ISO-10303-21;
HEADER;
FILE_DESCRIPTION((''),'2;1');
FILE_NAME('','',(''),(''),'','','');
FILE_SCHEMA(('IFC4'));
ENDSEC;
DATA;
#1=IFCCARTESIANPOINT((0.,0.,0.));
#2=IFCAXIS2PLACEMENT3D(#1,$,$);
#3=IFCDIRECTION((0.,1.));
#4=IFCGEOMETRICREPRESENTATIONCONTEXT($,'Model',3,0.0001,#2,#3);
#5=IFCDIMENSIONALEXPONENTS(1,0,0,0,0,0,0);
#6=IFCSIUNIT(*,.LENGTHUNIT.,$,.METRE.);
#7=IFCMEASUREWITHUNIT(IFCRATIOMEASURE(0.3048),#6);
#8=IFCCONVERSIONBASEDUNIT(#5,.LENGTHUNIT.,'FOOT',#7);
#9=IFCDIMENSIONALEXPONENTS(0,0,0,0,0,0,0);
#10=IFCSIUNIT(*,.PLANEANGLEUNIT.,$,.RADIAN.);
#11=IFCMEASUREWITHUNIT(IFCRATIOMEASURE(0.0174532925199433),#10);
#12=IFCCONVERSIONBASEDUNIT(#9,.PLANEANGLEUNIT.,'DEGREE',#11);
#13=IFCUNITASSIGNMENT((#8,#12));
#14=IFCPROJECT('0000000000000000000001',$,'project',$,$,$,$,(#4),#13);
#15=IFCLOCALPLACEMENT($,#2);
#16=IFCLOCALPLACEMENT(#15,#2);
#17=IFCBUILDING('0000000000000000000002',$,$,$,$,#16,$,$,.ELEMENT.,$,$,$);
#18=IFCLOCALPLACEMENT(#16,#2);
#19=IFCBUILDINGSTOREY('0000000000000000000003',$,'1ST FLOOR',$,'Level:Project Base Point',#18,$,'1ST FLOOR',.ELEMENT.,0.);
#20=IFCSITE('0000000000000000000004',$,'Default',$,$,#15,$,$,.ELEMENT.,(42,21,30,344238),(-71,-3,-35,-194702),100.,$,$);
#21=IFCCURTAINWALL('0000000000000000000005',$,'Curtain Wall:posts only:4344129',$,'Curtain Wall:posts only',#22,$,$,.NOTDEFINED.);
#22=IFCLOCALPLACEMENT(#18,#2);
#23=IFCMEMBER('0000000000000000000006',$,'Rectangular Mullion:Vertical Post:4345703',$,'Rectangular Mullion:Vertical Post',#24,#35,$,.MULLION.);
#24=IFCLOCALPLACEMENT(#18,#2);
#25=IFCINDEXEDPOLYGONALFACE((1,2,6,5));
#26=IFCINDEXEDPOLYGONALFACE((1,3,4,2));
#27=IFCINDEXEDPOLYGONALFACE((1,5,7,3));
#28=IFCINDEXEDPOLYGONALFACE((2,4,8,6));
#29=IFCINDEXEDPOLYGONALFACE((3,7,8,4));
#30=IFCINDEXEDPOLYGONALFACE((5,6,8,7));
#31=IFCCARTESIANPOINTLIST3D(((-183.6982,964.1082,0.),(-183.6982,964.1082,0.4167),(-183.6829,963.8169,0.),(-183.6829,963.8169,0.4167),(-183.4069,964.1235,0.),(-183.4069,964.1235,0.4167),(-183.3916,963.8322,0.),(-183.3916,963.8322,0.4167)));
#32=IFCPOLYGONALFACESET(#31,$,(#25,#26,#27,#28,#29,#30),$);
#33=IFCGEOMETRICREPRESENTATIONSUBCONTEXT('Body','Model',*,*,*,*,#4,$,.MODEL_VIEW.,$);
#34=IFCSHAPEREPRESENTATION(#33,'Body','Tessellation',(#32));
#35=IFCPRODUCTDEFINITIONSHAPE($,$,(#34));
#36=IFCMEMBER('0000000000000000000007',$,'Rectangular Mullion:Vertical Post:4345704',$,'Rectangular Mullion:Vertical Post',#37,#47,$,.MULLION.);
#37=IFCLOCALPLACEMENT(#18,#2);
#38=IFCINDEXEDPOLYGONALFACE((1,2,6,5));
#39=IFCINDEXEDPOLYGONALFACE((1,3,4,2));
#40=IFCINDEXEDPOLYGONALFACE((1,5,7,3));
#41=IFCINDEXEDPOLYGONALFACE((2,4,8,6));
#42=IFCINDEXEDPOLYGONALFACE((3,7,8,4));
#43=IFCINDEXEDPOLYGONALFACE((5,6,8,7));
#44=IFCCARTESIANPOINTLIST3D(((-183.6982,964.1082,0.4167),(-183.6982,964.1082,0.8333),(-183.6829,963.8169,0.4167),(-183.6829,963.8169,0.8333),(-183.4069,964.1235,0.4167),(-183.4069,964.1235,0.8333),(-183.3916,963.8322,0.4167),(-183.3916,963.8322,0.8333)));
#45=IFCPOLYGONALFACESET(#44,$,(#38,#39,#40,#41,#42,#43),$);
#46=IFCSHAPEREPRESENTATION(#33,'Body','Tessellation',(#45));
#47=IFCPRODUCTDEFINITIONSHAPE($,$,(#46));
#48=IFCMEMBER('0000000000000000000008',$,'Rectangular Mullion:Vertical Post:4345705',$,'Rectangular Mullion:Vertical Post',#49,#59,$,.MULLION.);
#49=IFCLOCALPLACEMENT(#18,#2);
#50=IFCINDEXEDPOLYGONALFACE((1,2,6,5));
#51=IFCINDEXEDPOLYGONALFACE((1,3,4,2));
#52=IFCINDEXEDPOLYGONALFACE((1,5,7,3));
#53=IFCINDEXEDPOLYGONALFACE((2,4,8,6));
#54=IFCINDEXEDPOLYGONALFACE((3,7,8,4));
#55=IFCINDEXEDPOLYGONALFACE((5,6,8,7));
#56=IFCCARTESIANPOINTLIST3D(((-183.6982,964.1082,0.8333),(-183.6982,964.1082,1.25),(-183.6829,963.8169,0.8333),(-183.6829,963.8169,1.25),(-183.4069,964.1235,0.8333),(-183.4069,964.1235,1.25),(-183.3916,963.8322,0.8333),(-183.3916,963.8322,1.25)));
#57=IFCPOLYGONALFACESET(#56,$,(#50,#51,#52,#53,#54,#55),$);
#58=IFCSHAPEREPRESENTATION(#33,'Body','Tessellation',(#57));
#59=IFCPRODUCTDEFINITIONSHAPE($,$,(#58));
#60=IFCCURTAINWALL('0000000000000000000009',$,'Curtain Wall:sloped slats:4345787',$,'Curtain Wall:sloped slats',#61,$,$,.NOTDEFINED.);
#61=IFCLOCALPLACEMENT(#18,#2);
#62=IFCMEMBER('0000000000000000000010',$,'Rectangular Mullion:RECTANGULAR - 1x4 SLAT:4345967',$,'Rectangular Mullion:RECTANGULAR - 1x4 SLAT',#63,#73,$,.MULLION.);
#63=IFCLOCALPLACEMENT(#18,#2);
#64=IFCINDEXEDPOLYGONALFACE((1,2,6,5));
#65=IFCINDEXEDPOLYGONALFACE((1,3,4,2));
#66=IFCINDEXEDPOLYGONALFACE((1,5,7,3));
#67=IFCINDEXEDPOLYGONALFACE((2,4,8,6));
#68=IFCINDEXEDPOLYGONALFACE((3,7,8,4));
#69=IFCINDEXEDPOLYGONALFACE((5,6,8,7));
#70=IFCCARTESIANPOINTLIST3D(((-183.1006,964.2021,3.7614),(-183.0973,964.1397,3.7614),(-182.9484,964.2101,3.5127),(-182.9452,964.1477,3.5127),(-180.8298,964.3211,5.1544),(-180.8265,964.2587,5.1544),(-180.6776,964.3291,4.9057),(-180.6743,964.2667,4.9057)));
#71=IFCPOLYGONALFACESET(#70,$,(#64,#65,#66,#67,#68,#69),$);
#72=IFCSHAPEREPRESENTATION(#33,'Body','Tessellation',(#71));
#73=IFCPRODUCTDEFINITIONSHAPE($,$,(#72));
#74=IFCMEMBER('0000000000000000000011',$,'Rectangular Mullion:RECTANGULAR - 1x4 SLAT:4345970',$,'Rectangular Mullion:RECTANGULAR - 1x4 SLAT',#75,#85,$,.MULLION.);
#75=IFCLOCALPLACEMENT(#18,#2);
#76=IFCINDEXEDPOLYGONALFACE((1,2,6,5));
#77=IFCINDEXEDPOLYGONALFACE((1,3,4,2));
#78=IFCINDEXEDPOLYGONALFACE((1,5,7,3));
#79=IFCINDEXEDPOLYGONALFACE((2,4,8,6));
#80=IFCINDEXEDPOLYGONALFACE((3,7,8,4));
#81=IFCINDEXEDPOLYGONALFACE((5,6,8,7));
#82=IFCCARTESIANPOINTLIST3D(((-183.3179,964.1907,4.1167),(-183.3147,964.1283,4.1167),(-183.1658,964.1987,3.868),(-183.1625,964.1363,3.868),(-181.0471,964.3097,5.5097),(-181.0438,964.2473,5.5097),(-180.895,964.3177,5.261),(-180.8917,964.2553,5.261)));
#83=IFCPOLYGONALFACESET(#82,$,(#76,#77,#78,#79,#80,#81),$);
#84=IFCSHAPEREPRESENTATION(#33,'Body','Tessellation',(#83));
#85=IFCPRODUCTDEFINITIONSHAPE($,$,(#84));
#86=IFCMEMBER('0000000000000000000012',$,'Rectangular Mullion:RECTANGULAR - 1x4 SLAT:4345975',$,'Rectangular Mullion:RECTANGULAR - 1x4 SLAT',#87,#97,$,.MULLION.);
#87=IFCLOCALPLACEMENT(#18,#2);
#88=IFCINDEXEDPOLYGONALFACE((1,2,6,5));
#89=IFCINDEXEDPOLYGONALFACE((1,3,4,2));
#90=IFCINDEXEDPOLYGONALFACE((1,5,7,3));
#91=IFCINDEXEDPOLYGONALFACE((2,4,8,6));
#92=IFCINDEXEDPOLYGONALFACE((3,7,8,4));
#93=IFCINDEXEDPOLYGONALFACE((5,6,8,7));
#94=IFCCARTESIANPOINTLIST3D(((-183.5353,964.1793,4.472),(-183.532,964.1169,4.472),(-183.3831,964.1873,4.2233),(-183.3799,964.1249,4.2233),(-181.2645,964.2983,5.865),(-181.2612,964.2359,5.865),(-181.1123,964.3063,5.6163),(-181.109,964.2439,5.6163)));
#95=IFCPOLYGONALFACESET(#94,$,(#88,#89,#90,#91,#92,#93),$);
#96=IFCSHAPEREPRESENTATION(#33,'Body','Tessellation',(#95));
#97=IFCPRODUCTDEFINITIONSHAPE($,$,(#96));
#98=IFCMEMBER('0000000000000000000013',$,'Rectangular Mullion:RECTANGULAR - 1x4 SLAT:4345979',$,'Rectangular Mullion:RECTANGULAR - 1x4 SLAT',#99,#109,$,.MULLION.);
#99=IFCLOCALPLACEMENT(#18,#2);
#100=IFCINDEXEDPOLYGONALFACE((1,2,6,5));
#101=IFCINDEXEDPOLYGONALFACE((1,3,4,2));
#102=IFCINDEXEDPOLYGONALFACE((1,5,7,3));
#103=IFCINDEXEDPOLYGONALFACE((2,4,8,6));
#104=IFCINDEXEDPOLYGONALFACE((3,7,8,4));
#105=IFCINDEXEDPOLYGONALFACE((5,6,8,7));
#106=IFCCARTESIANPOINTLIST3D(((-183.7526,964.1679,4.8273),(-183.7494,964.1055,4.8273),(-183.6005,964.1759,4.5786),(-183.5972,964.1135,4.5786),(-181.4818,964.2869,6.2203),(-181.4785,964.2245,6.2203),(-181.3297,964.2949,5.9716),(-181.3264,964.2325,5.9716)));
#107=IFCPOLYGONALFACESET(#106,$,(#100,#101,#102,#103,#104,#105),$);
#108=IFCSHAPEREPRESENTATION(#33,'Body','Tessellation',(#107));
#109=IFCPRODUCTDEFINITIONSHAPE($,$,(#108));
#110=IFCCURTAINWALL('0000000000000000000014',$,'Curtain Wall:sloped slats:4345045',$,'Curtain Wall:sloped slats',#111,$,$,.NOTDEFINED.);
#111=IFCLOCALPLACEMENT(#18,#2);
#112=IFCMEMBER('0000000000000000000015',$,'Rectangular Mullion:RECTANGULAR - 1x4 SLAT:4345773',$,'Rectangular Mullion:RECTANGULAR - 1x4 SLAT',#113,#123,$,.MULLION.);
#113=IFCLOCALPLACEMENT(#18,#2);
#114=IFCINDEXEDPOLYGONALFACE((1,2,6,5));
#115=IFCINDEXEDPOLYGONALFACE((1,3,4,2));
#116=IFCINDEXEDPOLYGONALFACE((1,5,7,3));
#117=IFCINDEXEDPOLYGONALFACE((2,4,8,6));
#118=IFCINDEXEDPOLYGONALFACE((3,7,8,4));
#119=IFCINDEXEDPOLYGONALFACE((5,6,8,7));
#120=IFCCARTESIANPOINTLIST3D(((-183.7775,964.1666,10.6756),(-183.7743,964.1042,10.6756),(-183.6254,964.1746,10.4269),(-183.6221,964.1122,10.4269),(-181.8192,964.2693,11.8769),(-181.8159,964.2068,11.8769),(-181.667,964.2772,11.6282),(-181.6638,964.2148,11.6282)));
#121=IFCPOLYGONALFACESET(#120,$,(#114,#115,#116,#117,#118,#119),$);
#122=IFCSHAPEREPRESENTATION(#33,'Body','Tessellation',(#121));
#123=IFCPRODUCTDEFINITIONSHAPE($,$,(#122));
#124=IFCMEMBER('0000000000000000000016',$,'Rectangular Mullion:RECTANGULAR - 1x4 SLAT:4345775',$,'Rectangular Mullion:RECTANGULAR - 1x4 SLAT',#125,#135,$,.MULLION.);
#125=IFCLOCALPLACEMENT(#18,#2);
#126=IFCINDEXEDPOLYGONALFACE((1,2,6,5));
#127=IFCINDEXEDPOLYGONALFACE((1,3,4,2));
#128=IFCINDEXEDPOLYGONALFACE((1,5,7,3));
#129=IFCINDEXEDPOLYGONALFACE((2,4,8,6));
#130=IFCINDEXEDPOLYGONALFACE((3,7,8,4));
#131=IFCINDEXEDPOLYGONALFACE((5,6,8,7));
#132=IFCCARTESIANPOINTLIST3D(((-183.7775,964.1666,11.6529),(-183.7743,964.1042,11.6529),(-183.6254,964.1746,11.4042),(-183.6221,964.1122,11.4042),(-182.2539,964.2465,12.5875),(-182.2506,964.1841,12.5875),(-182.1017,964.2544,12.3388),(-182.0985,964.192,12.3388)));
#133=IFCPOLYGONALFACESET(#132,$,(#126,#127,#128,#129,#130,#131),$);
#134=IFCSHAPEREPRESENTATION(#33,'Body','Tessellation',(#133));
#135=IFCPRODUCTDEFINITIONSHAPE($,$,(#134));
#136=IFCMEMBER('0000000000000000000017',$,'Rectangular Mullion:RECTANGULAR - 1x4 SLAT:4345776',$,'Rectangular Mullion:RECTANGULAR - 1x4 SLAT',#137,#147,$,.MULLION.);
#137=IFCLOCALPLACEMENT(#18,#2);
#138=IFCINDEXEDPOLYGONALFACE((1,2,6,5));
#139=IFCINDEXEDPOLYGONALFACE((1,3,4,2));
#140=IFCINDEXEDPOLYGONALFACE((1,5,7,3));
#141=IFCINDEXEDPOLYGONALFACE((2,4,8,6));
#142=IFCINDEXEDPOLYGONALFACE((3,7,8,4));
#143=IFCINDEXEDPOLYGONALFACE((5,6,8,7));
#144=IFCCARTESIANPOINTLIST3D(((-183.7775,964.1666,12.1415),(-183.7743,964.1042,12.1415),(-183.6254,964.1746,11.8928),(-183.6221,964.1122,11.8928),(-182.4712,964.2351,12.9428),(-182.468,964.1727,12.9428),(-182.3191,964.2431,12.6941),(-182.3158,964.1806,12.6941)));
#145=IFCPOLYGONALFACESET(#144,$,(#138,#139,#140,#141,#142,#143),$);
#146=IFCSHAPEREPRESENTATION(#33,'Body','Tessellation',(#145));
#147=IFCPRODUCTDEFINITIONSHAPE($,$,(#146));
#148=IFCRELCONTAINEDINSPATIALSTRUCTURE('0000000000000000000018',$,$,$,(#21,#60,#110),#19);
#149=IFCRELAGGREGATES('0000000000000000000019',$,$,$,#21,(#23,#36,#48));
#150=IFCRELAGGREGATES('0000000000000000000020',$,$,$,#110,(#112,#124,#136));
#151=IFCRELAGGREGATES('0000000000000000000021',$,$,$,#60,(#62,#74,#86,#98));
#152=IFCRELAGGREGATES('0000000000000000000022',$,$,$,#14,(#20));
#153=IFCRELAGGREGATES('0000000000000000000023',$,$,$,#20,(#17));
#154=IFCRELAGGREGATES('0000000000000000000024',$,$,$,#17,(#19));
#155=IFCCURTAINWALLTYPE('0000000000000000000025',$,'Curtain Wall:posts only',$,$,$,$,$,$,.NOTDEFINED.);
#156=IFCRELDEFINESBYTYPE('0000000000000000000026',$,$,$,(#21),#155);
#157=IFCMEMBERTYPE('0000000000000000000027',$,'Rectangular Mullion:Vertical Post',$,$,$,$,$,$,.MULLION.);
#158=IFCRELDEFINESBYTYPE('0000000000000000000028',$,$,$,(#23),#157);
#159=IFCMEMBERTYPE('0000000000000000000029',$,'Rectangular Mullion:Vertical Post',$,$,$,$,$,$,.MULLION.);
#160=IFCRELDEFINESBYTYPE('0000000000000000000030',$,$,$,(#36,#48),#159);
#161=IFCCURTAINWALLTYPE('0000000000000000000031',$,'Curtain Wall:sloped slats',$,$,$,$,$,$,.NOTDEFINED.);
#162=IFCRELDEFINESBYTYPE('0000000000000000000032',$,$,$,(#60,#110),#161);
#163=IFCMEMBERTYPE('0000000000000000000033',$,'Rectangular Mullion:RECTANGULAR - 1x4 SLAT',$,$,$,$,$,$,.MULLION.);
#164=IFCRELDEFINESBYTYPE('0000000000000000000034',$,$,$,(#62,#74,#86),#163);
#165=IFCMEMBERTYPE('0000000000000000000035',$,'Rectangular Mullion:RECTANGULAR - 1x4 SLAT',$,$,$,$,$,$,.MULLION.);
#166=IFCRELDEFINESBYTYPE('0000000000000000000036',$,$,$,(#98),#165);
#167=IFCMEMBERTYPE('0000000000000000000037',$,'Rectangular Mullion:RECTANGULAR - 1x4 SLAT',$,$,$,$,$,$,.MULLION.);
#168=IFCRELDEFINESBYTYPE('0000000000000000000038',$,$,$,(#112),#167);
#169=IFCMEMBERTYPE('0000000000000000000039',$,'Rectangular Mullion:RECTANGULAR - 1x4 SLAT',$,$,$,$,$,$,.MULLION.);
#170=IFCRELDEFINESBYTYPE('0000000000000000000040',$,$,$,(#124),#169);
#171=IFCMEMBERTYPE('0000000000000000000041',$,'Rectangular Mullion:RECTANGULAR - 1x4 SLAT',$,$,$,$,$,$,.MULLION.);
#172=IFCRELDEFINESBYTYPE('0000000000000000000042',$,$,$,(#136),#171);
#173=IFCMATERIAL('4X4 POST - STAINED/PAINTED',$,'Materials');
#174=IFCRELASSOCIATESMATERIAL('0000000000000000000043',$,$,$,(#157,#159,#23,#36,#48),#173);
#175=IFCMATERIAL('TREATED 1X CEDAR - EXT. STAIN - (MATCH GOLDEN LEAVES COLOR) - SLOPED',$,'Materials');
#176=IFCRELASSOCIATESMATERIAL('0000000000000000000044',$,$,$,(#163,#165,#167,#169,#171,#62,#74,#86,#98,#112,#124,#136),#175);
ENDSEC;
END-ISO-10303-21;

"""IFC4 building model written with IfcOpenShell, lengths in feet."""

from ifc_helpers import new_model, entity, si_unit, converted_unit, direction, frame, frame_2d, origin, origin_2d_with_axis, place, context, subcontext, project, spatial, rectangle, extrude, source, transform, mapped, material, material_profile, profile_set, profile_usage, type_object, type_shapes, element, aggregate, save


model = new_model("IFC4")

# Units and contexts
model_context = context("Model", 3, precision=0.0001, world=origin(), true_north=direction((0.0, 1.0)))
body_context = subcontext(model_context, "Body", "Model", "MODEL_VIEW")
ifc_project = project(units=[converted_unit("LENGTHUNIT", "FOOT", entity("IfcRatioMeasure", 0.3048), si_unit("LENGTHUNIT", "METRE"), dimensions=[1, 0, 0, 0, 0, 0, 0]), converted_unit("PLANEANGLEUNIT", "DEGREE", entity("IfcRatioMeasure", 0.0174532925199433), si_unit("PLANEANGLEUNIT", "RADIAN"), dimensions=[0, 0, 0, 0, 0, 0, 0])], contexts=[model_context])

# Site, building, storey
site_placement = place(None, origin())
site = spatial("IfcSite", under=ifc_project, at=site_placement, Name="Default", CompositionType="ELEMENT", RefLatitude=(42, 21, 30, 344238), RefLongitude=(-71, -3, -35, -194702), RefElevation=100.0)
building_placement = place(site_placement, origin())
building = spatial("IfcBuilding", under=site, at=building_placement, CompositionType="ELEMENT")
storey_placement = place(building_placement, origin())
storey = spatial("IfcBuildingStorey", under=building, at=storey_placement, Name="1ST FLOOR", ObjectType="Level:Project Base Point", LongName="1ST FLOOR", CompositionType="ELEMENT", Elevation=0.0)

# Curtain walls, members
curtain_wall_type_1 = type_object("IfcCurtainWallType", Name="Curtain Wall:posts only", PredefinedType="NOTDEFINED")
curtain_wall_1_placement = place(storey_placement, origin())
curtain_wall_1 = element("IfcCurtainWall", 1, at=curtain_wall_1_placement, inside=storey, type_object=curtain_wall_type_1, Name="Curtain Wall:posts only:4344129", ObjectType="Curtain Wall:posts only", PredefinedType="NOTDEFINED")
ifc_material_1 = material(Name="4X4 POST - STAINED/PAINTED", Category="Materials")
ifc_material_profile_1 = material_profile(ifc_material_1, rectangle(XDim=0.2917, YDim=0.2917, at=origin_2d_with_axis()), Name="Vertical Post")
ifc_profile_set_1 = profile_set([ifc_material_profile_1], Name="Vertical Post")
ifc_profile_usage_1 = profile_usage(ifc_profile_set_1)
member_type_1 = type_object("IfcMemberType", Name="Rectangular Mullion:Vertical Post", PredefinedType="MULLION", material=ifc_profile_set_1)
shared_shape_1 = source(origin(), body_context, "Body", "SweptSolid", [
    extrude(rectangle(XDim=0.2917, YDim=0.2917, at=origin_2d_with_axis()), frame((0.0, -0.2083, -0.4167), z_axis=(0.0, 0.0, 1.0), x_axis=(0.0, -1.0, 0.0)), (0.0, 0.0, 1.0), 0.4167),
])
type_shapes(member_type_1, [shared_shape_1])
member_1_placement = place(storey_placement, frame((-183.5558, 964.1782, 0.0), z_axis=(0.0, 0.0, -1.0), x_axis=(-0.99863, -0.052336, 0.0)))
member_1 = element("IfcMember", 2, at=member_1_placement, type_object=member_type_1, material=ifc_profile_usage_1, Name="Rectangular Mullion:Vertical Post:4345703", ObjectType="Rectangular Mullion:Vertical Post", PredefinedType="MULLION", context=body_context, shape_type="MappedRepresentation", body=[
    mapped(shared_shape_1, transform((0.0, 0.0, 0.0), scale=1.0)),
])
ifc_profile_usage_2 = profile_usage(ifc_profile_set_1)
member_type_2 = type_object("IfcMemberType", Name="Rectangular Mullion:Vertical Post", PredefinedType="MULLION", material=ifc_profile_set_1)
shared_shape_2 = source(origin(), body_context, "Body", "SweptSolid", [
    extrude(rectangle(XDim=0.2917, YDim=0.2917, at=origin_2d_with_axis()), frame((0.0, -0.2083, -0.4167), z_axis=(0.0, 0.0, 1.0), x_axis=(0.0, -1.0, 0.0)), (0.0, 0.0, 1.0), 0.4167),
])
type_shapes(member_type_2, [shared_shape_2])
member_2_placement = place(storey_placement, frame((-183.5558, 964.1782, 0.4167), z_axis=(0.0, 0.0, -1.0), x_axis=(-0.99863, -0.052336, 0.0)))
member_2 = element("IfcMember", 3, at=member_2_placement, type_object=member_type_2, material=ifc_profile_usage_2, Name="Rectangular Mullion:Vertical Post:4345704", ObjectType="Rectangular Mullion:Vertical Post", PredefinedType="MULLION", context=body_context, shape_type="MappedRepresentation", body=[
    mapped(shared_shape_2, transform((0.0, 0.0, 0.0), scale=1.0)),
])
ifc_profile_usage_3 = profile_usage(ifc_profile_set_1)
member_3_placement = place(storey_placement, frame((-183.5558, 964.1782, 0.8333), z_axis=(0.0, 0.0, -1.0), x_axis=(-0.99863, -0.052336, 0.0)))
member_3 = element("IfcMember", 4, at=member_3_placement, type_object=member_type_2, material=ifc_profile_usage_3, Name="Rectangular Mullion:Vertical Post:4345705", ObjectType="Rectangular Mullion:Vertical Post", PredefinedType="MULLION", context=body_context, shape_type="MappedRepresentation", body=[
    mapped(shared_shape_2, transform((0.0, 0.0, 0.0), scale=1.0)),
])
aggregate(curtain_wall_1, [member_1, member_2, member_3])
curtain_wall_type_2 = type_object("IfcCurtainWallType", Name="Curtain Wall:sloped slats", PredefinedType="NOTDEFINED")
curtain_wall_2_placement = place(storey_placement, origin())
curtain_wall_2 = element("IfcCurtainWall", 5, at=curtain_wall_2_placement, inside=storey, type_object=curtain_wall_type_2, Name="Curtain Wall:sloped slats:4345787", ObjectType="Curtain Wall:sloped slats", PredefinedType="NOTDEFINED")
ifc_material_2 = material(Name="TREATED 1X CEDAR - EXT. STAIN - (MATCH GOLDEN LEAVES COLOR) - SLOPED", Category="Materials")
ifc_material_profile_2 = material_profile(ifc_material_2, rectangle(XDim=0.0625, YDim=0.2917, at=frame_2d((0.0, 0.0), x_axis=(1.0, 0.0))), Name="RECTANGULAR - 1x4 SLAT")
ifc_profile_set_2 = profile_set([ifc_material_profile_2], Name="RECTANGULAR - 1x4 SLAT")
ifc_profile_usage_4 = profile_usage(ifc_profile_set_2)
member_type_3 = type_object("IfcMemberType", Name="Rectangular Mullion:RECTANGULAR - 1x4 SLAT", PredefinedType="MULLION", material=ifc_profile_set_2)
shared_shape_3 = source(origin(), body_context, "Body", "SweptSolid", [
    extrude(rectangle(XDim=0.0625, YDim=0.2917, at=frame_2d((0.0, 0.0), x_axis=(1.0, 0.0))), frame((0.0, 0.0, -2.6667), z_axis=(0.0, 0.0, 1.0), x_axis=(0.0, -1.0, 0.0)), (0.0, 0.0, 1.0), 2.6667),
])
type_shapes(member_type_3, [shared_shape_3])
member_4_placement = place(storey_placement, frame((-183.0229, 964.1749, 3.6371), z_axis=(-0.851559, -0.044628, -0.522356), x_axis=(-0.52164, -0.027338, 0.852727)))
member_4 = element("IfcMember", 6, at=member_4_placement, type_object=member_type_3, material=ifc_profile_usage_4, Name="Rectangular Mullion:RECTANGULAR - 1x4 SLAT:4345967", ObjectType="Rectangular Mullion:RECTANGULAR - 1x4 SLAT", PredefinedType="MULLION", context=body_context, shape_type="MappedRepresentation", body=[
    mapped(shared_shape_3, transform((0.0, 0.0, 0.0), scale=1.0)),
])
ifc_profile_usage_5 = profile_usage(ifc_profile_set_2)
member_5_placement = place(storey_placement, frame((-183.2402, 964.1635, 3.9924), z_axis=(-0.851559, -0.044628, -0.522356), x_axis=(-0.52164, -0.027338, 0.852727)))
member_5 = element("IfcMember", 7, at=member_5_placement, type_object=member_type_3, material=ifc_profile_usage_5, Name="Rectangular Mullion:RECTANGULAR - 1x4 SLAT:4345970", ObjectType="Rectangular Mullion:RECTANGULAR - 1x4 SLAT", PredefinedType="MULLION", context=body_context, shape_type="MappedRepresentation", body=[
    mapped(shared_shape_3, transform((0.0, 0.0, 0.0), scale=1.0)),
])
ifc_profile_usage_6 = profile_usage(ifc_profile_set_2)
member_6_placement = place(storey_placement, frame((-183.4576, 964.1521, 4.3477), z_axis=(-0.851559, -0.044628, -0.522356), x_axis=(-0.52164, -0.027338, 0.852727)))
member_6 = element("IfcMember", 8, at=member_6_placement, type_object=member_type_3, material=ifc_profile_usage_6, Name="Rectangular Mullion:RECTANGULAR - 1x4 SLAT:4345975", ObjectType="Rectangular Mullion:RECTANGULAR - 1x4 SLAT", PredefinedType="MULLION", context=body_context, shape_type="MappedRepresentation", body=[
    mapped(shared_shape_3, transform((0.0, 0.0, 0.0), scale=1.0)),
])
ifc_profile_usage_7 = profile_usage(ifc_profile_set_2)
member_type_4 = type_object("IfcMemberType", Name="Rectangular Mullion:RECTANGULAR - 1x4 SLAT", PredefinedType="MULLION", material=ifc_profile_set_2)
shared_shape_4 = source(origin(), body_context, "Body", "SweptSolid", [
    extrude(rectangle(XDim=0.0625, YDim=0.2917, at=frame_2d((0.0, 0.0), x_axis=(1.0, 0.0))), frame((0.0, 0.0, -2.6667), z_axis=(0.0, 0.0, 1.0), x_axis=(0.0, -1.0, 0.0)), (0.0, 0.0, 1.0), 2.6667),
])
type_shapes(member_type_4, [shared_shape_4])
member_7_placement = place(storey_placement, frame((-183.6749, 964.1407, 4.703), z_axis=(-0.851559, -0.044628, -0.522356), x_axis=(-0.52164, -0.027338, 0.852727)))
member_7 = element("IfcMember", 9, at=member_7_placement, type_object=member_type_4, material=ifc_profile_usage_7, Name="Rectangular Mullion:RECTANGULAR - 1x4 SLAT:4345979", ObjectType="Rectangular Mullion:RECTANGULAR - 1x4 SLAT", PredefinedType="MULLION", context=body_context, shape_type="MappedRepresentation", body=[
    mapped(shared_shape_4, transform((0.0, 0.0, 0.0), scale=1.0)),
])
curtain_wall_3_placement = place(storey_placement, origin())
curtain_wall_3 = element("IfcCurtainWall", 10, at=curtain_wall_3_placement, inside=storey, type_object=curtain_wall_type_2, Name="Curtain Wall:sloped slats:4345045", ObjectType="Curtain Wall:sloped slats", PredefinedType="NOTDEFINED")
ifc_profile_usage_8 = profile_usage(ifc_profile_set_2)
member_type_5 = type_object("IfcMemberType", Name="Rectangular Mullion:RECTANGULAR - 1x4 SLAT", PredefinedType="MULLION", material=ifc_profile_set_2)
shared_shape_5 = source(origin(), body_context, "Body", "SweptSolid", [
    extrude(rectangle(XDim=0.0625, YDim=0.2917, at=origin_2d_with_axis()), frame((0.0, 0.0, -2.2997), z_axis=(0.0, 0.0, 1.0), x_axis=(0.0, -1.0, 0.0)), (0.0, 0.0, 1.0), 2.2997),
])
type_shapes(member_type_5, [shared_shape_5])
member_8_placement = place(storey_placement, frame((-183.6998, 964.1394, 10.5513), z_axis=(-0.851559, -0.044628, -0.522356), x_axis=(-0.52164, -0.027338, 0.852727)))
member_8 = element("IfcMember", 11, at=member_8_placement, type_object=member_type_5, material=ifc_profile_usage_8, Name="Rectangular Mullion:RECTANGULAR - 1x4 SLAT:4345773", ObjectType="Rectangular Mullion:RECTANGULAR - 1x4 SLAT", PredefinedType="MULLION", context=body_context, shape_type="MappedRepresentation", body=[
    mapped(shared_shape_5, transform((0.0, 0.0, 0.0), scale=1.0)),
])
ifc_profile_usage_9 = profile_usage(ifc_profile_set_2)
member_type_6 = type_object("IfcMemberType", Name="Rectangular Mullion:RECTANGULAR - 1x4 SLAT", PredefinedType="MULLION", material=ifc_profile_set_2)
shared_shape_6 = source(origin(), body_context, "Body", "SweptSolid", [
    extrude(rectangle(XDim=0.0625, YDim=0.2917, at=frame_2d((0.0, 0.0), x_axis=(1.0, 0.0))), frame((0.0, 0.0, -1.7892), z_axis=(0.0, 0.0, 1.0), x_axis=(0.0, -1.0, 0.0)), (0.0, 0.0, 1.0), 1.7892),
])
type_shapes(member_type_6, [shared_shape_6])
member_9_placement = place(storey_placement, frame((-183.6998, 964.1394, 11.5285), z_axis=(-0.851559, -0.044628, -0.522356), x_axis=(-0.52164, -0.027338, 0.852727)))
member_9 = element("IfcMember", 12, at=member_9_placement, type_object=member_type_6, material=ifc_profile_usage_9, Name="Rectangular Mullion:RECTANGULAR - 1x4 SLAT:4345775", ObjectType="Rectangular Mullion:RECTANGULAR - 1x4 SLAT", PredefinedType="MULLION", context=body_context, shape_type="MappedRepresentation", body=[
    mapped(shared_shape_6, transform((0.0, 0.0, 0.0), scale=1.0)),
])
ifc_profile_usage_10 = profile_usage(ifc_profile_set_2)
member_type_7 = type_object("IfcMemberType", Name="Rectangular Mullion:RECTANGULAR - 1x4 SLAT", PredefinedType="MULLION", material=ifc_profile_set_2)
shared_shape_7 = source(origin(), body_context, "Body", "SweptSolid", [
    extrude(rectangle(XDim=0.0625, YDim=0.2917, at=origin_2d_with_axis()), frame((0.0, 0.0, -1.534), z_axis=(0.0, 0.0, 1.0), x_axis=(0.0, -1.0, 0.0)), (0.0, 0.0, 1.0), 1.534),
])
type_shapes(member_type_7, [shared_shape_7])
member_10_placement = place(storey_placement, frame((-183.6998, 964.1394, 12.0171), z_axis=(-0.851559, -0.044628, -0.522356), x_axis=(-0.52164, -0.027338, 0.852727)))
member_10 = element("IfcMember", 13, at=member_10_placement, type_object=member_type_7, material=ifc_profile_usage_10, Name="Rectangular Mullion:RECTANGULAR - 1x4 SLAT:4345776", ObjectType="Rectangular Mullion:RECTANGULAR - 1x4 SLAT", PredefinedType="MULLION", context=body_context, shape_type="MappedRepresentation", body=[
    mapped(shared_shape_7, transform((0.0, 0.0, 0.0), scale=1.0)),
])
aggregate(curtain_wall_3, [member_8, member_9, member_10])

aggregate(curtain_wall_2, [member_4, member_5, member_6, member_7])

save(model, "model.ifc")
